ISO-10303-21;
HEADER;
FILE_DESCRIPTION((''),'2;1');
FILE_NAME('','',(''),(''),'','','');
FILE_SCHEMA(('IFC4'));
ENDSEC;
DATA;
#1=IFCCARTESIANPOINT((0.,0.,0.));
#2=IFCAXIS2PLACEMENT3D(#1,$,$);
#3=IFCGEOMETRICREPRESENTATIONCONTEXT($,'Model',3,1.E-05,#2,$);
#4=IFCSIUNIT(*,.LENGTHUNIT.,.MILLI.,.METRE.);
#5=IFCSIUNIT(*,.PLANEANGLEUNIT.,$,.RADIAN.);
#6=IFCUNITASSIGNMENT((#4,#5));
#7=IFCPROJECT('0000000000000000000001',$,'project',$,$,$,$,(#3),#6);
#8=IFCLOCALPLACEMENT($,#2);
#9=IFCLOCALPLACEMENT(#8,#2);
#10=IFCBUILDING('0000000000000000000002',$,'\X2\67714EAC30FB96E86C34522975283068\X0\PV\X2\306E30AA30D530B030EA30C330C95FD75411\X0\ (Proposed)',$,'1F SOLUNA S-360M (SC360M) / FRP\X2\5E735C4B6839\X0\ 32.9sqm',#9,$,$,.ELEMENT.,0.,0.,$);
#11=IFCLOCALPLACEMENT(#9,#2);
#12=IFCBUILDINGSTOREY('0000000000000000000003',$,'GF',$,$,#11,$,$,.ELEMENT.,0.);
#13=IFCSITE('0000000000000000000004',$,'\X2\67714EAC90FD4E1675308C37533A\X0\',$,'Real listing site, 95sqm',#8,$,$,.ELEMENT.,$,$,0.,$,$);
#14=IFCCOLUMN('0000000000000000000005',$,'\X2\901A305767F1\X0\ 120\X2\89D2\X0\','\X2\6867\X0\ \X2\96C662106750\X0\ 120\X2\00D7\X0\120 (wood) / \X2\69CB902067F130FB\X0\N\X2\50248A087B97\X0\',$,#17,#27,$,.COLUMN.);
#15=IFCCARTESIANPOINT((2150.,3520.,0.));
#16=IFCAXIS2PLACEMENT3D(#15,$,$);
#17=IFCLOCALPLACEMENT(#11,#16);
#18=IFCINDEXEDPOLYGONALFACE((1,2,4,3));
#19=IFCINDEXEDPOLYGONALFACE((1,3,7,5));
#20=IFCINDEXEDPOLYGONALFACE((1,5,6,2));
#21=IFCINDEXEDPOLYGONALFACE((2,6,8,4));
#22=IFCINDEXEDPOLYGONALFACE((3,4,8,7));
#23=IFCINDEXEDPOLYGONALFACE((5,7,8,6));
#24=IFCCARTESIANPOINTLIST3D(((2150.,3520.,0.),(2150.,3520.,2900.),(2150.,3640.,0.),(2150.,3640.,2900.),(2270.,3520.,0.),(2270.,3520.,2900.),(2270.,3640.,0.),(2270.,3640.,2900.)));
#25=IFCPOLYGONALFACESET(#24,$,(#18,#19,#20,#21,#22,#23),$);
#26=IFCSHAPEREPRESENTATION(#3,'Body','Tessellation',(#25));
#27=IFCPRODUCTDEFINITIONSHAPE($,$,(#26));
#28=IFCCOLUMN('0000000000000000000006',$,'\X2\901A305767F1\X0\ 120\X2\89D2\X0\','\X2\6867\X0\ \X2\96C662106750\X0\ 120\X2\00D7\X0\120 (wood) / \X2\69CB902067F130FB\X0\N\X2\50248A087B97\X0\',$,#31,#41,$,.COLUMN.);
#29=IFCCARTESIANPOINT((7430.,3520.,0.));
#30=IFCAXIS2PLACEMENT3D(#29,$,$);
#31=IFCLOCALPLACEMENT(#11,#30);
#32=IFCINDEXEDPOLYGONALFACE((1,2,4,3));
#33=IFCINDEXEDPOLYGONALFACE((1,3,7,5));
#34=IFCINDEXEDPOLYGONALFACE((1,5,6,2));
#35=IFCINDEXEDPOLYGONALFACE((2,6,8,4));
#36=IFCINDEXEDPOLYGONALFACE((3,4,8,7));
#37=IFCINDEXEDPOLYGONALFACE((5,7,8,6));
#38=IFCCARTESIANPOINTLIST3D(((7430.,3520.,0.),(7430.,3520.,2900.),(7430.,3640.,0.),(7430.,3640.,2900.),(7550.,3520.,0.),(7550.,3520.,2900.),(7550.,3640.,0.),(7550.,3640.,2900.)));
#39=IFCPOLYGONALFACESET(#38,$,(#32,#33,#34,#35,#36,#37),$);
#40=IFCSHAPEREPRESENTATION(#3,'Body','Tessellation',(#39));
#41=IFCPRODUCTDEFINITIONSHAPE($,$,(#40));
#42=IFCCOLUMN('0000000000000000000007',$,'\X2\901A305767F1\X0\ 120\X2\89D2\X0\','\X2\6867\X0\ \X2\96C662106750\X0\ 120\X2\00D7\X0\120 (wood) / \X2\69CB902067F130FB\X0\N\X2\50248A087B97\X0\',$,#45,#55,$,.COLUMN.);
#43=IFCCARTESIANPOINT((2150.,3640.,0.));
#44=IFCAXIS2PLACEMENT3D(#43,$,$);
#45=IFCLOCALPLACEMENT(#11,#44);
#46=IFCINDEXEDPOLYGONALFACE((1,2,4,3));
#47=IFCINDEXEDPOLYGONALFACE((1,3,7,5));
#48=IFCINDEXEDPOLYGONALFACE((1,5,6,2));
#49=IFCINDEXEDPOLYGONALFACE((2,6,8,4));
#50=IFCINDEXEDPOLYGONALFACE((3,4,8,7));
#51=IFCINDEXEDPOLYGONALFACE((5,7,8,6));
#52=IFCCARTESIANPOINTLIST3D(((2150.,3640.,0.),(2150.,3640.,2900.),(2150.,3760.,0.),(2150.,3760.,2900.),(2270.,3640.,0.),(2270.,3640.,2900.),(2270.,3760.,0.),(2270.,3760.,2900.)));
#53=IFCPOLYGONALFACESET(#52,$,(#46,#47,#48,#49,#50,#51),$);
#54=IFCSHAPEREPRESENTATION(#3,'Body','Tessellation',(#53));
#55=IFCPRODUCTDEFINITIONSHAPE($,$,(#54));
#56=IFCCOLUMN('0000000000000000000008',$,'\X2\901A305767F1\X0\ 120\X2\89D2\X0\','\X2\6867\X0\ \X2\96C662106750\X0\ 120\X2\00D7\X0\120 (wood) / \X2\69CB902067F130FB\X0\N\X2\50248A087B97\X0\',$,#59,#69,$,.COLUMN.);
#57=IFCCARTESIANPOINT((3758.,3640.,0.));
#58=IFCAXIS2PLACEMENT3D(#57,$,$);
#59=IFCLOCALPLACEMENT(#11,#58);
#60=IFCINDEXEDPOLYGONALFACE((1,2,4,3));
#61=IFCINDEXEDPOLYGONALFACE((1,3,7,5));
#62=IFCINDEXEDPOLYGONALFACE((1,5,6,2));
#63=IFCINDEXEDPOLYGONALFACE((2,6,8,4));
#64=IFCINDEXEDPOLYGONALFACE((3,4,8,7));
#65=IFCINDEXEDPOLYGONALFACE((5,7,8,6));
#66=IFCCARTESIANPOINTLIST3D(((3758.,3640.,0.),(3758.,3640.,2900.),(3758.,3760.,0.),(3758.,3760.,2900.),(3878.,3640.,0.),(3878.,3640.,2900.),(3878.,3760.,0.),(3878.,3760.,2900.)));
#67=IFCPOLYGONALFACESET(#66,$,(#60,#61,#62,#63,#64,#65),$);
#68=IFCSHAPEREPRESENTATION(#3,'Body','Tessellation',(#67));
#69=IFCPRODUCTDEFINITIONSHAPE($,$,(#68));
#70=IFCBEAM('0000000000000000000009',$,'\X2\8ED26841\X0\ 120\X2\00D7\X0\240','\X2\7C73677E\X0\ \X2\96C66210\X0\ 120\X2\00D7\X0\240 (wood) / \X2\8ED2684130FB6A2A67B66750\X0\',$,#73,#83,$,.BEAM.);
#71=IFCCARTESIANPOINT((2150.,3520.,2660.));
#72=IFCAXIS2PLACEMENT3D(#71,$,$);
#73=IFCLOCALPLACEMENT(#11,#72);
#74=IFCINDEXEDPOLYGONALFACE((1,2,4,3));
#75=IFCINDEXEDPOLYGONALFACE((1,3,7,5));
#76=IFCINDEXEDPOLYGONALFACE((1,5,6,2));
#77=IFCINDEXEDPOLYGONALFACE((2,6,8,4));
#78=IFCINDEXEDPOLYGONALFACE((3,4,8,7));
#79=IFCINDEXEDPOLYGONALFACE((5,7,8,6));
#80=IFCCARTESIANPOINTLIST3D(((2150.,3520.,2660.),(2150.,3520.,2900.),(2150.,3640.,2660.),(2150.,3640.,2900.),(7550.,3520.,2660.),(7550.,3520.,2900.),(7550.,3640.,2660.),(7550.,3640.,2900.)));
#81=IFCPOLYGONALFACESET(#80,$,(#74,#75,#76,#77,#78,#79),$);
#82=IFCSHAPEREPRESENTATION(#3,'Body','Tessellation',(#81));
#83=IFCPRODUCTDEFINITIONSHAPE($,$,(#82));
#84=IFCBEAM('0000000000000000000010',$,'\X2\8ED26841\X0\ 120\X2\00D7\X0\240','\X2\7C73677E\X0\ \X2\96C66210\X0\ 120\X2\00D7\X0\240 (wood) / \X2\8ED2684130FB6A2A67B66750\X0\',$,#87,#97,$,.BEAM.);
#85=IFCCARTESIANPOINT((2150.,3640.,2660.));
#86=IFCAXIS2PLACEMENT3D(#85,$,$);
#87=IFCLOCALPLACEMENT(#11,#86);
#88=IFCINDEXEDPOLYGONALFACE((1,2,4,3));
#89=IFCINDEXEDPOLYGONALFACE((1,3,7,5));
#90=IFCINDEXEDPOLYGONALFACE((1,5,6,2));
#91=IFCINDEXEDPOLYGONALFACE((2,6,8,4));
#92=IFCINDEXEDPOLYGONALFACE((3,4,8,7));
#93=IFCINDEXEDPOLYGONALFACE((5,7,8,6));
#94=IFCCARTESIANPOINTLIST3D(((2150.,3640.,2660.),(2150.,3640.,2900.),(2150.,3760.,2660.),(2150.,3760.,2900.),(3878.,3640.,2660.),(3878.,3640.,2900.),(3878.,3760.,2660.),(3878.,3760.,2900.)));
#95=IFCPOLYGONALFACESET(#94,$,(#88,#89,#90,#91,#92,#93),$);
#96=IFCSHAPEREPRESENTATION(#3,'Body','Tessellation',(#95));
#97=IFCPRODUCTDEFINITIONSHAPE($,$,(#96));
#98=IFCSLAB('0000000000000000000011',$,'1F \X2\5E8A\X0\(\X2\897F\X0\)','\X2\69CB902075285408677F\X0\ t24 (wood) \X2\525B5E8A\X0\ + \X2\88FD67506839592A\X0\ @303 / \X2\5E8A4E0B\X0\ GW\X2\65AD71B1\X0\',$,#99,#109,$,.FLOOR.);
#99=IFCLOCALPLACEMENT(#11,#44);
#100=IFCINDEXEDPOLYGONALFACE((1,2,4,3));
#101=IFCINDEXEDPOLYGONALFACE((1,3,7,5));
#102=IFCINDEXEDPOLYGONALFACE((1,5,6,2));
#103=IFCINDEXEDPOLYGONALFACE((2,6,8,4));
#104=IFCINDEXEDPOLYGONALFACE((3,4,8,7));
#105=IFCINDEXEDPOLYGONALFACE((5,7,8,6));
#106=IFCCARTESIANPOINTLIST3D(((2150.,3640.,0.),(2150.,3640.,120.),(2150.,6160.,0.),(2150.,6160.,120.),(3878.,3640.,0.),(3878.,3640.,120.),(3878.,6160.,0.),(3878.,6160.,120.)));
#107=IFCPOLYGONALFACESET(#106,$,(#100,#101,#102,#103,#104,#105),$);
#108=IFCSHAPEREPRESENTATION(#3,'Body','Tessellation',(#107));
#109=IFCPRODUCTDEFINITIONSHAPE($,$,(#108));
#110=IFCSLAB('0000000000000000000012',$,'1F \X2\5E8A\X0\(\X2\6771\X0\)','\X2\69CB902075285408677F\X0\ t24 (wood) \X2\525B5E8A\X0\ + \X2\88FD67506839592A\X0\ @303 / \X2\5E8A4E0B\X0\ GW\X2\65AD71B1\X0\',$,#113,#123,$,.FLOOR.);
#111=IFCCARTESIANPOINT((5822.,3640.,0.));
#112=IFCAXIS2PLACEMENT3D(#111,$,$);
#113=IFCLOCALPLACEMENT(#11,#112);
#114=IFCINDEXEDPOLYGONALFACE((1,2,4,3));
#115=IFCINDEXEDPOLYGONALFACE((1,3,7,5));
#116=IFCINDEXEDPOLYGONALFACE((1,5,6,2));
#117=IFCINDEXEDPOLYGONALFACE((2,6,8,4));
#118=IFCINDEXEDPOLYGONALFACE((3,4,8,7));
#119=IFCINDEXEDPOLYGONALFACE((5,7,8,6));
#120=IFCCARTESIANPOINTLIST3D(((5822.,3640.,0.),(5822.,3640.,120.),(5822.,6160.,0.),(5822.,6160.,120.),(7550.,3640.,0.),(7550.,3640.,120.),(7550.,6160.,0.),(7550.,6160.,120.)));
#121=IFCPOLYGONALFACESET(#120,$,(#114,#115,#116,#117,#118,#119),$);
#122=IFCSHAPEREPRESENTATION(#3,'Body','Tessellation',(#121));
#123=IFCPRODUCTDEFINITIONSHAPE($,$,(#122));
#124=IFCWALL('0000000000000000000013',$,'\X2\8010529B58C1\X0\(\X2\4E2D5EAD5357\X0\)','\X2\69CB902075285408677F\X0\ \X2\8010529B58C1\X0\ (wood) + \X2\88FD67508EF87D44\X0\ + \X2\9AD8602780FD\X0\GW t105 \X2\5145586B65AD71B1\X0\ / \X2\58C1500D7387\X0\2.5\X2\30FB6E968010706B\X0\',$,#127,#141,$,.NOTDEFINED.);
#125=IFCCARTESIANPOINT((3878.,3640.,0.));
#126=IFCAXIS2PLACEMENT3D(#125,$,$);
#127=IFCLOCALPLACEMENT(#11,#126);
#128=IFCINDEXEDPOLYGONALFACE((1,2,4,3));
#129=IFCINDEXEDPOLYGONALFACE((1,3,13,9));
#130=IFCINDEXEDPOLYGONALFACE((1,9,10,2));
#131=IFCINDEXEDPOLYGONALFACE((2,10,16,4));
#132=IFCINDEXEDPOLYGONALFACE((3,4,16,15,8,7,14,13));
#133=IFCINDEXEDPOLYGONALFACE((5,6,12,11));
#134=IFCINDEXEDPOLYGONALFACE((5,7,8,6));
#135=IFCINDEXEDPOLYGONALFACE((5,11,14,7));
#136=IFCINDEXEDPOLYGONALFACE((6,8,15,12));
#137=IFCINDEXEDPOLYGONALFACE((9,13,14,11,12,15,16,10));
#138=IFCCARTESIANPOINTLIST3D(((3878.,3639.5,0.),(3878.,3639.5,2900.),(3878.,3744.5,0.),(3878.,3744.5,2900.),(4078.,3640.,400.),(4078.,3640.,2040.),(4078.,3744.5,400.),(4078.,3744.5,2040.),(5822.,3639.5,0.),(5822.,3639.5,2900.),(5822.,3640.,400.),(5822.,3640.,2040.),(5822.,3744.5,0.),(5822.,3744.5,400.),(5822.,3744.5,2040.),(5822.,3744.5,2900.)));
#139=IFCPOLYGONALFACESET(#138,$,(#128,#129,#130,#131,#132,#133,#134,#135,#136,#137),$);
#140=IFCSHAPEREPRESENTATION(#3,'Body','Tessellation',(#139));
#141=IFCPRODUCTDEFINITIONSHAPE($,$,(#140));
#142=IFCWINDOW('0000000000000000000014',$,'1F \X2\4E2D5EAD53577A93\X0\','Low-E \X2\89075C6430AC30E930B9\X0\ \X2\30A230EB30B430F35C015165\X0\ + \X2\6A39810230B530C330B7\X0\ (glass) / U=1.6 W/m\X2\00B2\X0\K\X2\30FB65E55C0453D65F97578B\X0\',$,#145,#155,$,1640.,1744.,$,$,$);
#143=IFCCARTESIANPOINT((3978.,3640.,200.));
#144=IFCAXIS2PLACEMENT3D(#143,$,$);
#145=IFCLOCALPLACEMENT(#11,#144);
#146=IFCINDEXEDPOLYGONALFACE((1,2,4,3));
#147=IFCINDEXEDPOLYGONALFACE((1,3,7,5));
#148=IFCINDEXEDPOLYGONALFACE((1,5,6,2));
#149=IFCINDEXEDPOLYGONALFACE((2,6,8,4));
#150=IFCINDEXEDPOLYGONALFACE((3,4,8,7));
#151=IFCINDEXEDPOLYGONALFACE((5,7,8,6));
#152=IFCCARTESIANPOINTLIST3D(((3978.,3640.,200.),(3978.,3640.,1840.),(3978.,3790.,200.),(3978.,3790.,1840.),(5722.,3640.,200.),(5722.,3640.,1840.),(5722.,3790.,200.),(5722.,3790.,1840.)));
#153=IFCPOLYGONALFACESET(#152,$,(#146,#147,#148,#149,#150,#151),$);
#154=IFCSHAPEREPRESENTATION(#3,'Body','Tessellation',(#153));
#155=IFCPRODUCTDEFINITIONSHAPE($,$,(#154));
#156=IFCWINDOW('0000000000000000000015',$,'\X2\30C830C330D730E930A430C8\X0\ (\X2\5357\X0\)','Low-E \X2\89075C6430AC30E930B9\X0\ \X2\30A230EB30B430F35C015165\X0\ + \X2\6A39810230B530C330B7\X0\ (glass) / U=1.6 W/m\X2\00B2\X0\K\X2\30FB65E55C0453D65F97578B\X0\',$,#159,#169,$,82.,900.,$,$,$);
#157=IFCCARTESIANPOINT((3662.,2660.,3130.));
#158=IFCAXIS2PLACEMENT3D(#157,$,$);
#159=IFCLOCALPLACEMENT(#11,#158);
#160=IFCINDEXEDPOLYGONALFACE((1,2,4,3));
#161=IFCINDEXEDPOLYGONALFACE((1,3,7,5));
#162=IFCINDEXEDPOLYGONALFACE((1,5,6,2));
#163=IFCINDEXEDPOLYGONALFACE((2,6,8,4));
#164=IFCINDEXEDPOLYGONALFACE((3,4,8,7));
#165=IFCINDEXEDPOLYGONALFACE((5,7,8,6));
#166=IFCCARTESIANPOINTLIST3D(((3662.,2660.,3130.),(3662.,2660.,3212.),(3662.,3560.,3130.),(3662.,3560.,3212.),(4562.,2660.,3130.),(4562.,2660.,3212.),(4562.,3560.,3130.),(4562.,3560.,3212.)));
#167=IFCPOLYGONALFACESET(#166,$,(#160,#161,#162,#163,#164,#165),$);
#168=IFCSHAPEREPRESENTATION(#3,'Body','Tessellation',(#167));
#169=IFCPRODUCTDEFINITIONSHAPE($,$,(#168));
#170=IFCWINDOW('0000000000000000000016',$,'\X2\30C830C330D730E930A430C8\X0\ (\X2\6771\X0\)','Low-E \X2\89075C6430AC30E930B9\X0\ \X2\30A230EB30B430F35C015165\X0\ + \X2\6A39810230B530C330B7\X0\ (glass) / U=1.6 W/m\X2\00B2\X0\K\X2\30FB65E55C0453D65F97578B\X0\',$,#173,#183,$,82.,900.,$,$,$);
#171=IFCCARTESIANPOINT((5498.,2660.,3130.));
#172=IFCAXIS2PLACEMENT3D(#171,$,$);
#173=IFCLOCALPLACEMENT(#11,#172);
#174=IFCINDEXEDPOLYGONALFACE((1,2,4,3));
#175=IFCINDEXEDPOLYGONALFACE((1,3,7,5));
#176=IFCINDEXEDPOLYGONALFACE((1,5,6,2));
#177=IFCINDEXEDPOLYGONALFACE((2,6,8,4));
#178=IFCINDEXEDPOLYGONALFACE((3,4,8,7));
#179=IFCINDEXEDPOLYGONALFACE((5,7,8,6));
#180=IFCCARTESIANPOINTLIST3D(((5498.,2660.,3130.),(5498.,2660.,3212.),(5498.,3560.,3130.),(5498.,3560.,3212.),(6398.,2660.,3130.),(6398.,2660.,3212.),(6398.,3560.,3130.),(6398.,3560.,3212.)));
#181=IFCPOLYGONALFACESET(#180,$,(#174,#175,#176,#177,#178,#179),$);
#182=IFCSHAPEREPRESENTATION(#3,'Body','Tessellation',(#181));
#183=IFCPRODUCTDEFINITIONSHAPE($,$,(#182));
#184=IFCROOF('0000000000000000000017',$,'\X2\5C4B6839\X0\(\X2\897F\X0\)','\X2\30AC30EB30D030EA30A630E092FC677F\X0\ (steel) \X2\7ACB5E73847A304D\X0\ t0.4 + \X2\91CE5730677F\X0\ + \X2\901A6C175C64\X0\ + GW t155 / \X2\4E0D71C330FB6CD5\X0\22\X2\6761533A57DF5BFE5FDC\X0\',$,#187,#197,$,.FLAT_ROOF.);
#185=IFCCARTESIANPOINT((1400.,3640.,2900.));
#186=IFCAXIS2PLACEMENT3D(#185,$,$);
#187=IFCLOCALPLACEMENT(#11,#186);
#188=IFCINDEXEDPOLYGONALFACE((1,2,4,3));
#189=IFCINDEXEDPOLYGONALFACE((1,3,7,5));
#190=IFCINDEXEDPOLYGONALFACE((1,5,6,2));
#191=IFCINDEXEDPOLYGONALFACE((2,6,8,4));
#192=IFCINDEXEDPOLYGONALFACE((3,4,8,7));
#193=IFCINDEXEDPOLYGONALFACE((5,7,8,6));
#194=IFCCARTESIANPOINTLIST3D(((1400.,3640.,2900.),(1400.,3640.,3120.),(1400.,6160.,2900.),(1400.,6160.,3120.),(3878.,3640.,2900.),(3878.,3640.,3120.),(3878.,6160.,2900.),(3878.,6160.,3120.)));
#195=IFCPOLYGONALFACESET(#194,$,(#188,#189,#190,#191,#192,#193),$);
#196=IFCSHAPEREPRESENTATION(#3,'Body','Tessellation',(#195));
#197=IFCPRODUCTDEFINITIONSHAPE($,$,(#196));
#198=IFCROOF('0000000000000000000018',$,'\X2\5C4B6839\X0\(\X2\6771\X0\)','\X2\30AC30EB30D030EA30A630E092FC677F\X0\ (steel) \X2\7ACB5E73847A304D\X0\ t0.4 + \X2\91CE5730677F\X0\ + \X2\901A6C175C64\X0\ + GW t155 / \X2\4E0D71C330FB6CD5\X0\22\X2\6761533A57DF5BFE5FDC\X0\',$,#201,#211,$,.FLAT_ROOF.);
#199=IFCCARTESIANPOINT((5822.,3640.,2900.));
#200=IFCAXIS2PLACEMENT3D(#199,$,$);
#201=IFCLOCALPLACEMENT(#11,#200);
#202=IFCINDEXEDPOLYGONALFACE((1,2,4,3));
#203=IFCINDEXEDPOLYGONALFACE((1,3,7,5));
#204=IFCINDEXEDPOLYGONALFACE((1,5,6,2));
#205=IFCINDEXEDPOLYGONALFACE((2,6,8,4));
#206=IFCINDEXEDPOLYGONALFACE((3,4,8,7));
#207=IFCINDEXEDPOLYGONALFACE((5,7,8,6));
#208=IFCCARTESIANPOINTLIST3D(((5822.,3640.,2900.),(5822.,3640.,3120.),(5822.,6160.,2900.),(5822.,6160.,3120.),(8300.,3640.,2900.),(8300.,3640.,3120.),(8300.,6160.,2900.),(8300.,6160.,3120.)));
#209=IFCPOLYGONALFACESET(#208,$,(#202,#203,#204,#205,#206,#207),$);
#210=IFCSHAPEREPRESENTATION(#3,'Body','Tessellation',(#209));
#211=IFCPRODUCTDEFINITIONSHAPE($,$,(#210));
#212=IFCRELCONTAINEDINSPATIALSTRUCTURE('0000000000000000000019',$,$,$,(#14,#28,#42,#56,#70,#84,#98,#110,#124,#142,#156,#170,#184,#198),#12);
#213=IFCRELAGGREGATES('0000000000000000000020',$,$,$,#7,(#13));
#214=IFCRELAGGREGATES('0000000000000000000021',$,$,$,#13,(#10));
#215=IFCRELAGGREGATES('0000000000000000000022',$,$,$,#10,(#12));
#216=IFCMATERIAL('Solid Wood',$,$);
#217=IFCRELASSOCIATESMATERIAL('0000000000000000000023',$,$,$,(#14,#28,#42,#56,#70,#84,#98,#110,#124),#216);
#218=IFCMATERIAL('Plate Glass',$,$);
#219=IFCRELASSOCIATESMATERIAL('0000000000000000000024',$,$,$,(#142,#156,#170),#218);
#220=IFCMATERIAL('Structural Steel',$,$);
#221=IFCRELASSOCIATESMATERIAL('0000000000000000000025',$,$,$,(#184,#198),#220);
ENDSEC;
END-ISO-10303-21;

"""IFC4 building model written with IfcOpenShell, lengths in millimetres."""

from ifc_helpers import new_model, si_unit, frame, frame_2d, origin, place, context, project, spatial, rectangle, extrude, material, element, fill, save


model = new_model("IFC4")

# Units and contexts
model_context = context("Model", 3, precision=1e-05, world=origin())
ifc_project = project(units=[si_unit("LENGTHUNIT", "METRE", prefix="MILLI"), si_unit("PLANEANGLEUNIT", "RADIAN")], contexts=[model_context])

# Site, building, storey
site_placement = place(None, origin())
site = spatial("IfcSite", under=ifc_project, at=site_placement, Name="東京都世田谷区", ObjectType="Real listing site, 95sqm", CompositionType="ELEMENT", RefElevation=0.0)
building_placement = place(site_placement, origin())
building = spatial("IfcBuilding", under=site, at=building_placement, Name="東京・雨水利用とPVのオフグリッド志向 (Proposed)", ObjectType="1F SOLUNA S-360M (SC360M) / FRP平屋根 32.9sqm", CompositionType="ELEMENT", ElevationOfRefHeight=0.0, ElevationOfTerrain=0.0)
storey_placement = place(building_placement, origin())
storey = spatial("IfcBuildingStorey", under=building, at=storey_placement, Name="GF", CompositionType="ELEMENT", Elevation=0.0)

# Columns
ifc_material_1 = material(Name="Solid Wood")
column_1_placement = place(storey_placement, frame((2150.0, 3520.0, 0.0)))
element("IfcColumn", 1, at=column_1_placement, inside=storey, material=ifc_material_1, Name="通し柱 120角", Description="桧 集成材 120×120 (wood) / 構造柱・N値計算", PredefinedType="COLUMN", context=model_context, shape_type="SweptSolid", body=[
    extrude(rectangle(XDim=120.0, YDim=120.0, at=frame_2d((60.0, 60.0))), frame((2150.0, 3520.0, 0.0)), (0.0, 0.0, 1.0), 2900.0),
])
column_2_placement = place(storey_placement, frame((7430.0, 3520.0, 0.0)))
element("IfcColumn", 2, at=column_2_placement, inside=storey, material=ifc_material_1, Name="通し柱 120角", Description="桧 集成材 120×120 (wood) / 構造柱・N値計算", PredefinedType="COLUMN", context=model_context, shape_type="SweptSolid", body=[
    extrude(rectangle(XDim=120.0, YDim=120.0, at=frame_2d((60.0, 60.0))), frame((7430.0, 3520.0, 0.0)), (0.0, 0.0, 1.0), 2900.0),
])
column_3_placement = place(storey_placement, frame((2150.0, 3640.0, 0.0)))
element("IfcColumn", 3, at=column_3_placement, inside=storey, material=ifc_material_1, Name="通し柱 120角", Description="桧 集成材 120×120 (wood) / 構造柱・N値計算", PredefinedType="COLUMN", context=model_context, shape_type="SweptSolid", body=[
    extrude(rectangle(XDim=120.0, YDim=120.0, at=frame_2d((60.0, 60.0))), frame((2150.0, 3640.0, 0.0)), (0.0, 0.0, 1.0), 2900.0),
])
column_4_placement = place(storey_placement, frame((3758.0, 3640.0, 0.0)))
element("IfcColumn", 4, at=column_4_placement, inside=storey, material=ifc_material_1, Name="通し柱 120角", Description="桧 集成材 120×120 (wood) / 構造柱・N値計算", PredefinedType="COLUMN", context=model_context, shape_type="SweptSolid", body=[
    extrude(rectangle(XDim=120.0, YDim=120.0, at=frame_2d((60.0, 60.0))), frame((3758.0, 3640.0, 0.0)), (0.0, 0.0, 1.0), 2900.0),
])

# Beams
beam_1_placement = place(storey_placement, frame((2150.0, 3520.0, 2660.0)))
element("IfcBeam", 5, at=beam_1_placement, inside=storey, material=ifc_material_1, Name="軒桁 120×240", Description="米松 集成 120×240 (wood) / 軒桁・横架材", PredefinedType="BEAM", context=model_context, shape_type="SweptSolid", body=[
    extrude(rectangle(XDim=5400.0, YDim=120.0, at=frame_2d((2700.0, 60.0))), frame((2150.0, 3520.0, 2660.0)), (0.0, 0.0, 1.0), 240.0),
])
beam_2_placement = place(storey_placement, frame((2150.0, 3640.0, 2660.0)))
element("IfcBeam", 6, at=beam_2_placement, inside=storey, material=ifc_material_1, Name="軒桁 120×240", Description="米松 集成 120×240 (wood) / 軒桁・横架材", PredefinedType="BEAM", context=model_context, shape_type="SweptSolid", body=[
    extrude(rectangle(XDim=1728.0, YDim=120.0, at=frame_2d((864.0, 60.0))), frame((2150.0, 3640.0, 2660.0)), (0.0, 0.0, 1.0), 240.0),
])

# Slabs
slab_1_placement = place(storey_placement, frame((2150.0, 3640.0, 0.0)))
element("IfcSlab", 7, at=slab_1_placement, inside=storey, material=ifc_material_1, Name="1F 床(西)", Description="構造用合板 t24 (wood) 剛床 + 製材根太 @303 / 床下 GW断熱", PredefinedType="FLOOR", context=model_context, shape_type="SweptSolid", body=[
    extrude(rectangle(XDim=1728.0, YDim=2520.0, at=frame_2d((864.0, 1260.0))), frame((2150.0, 3640.0, 0.0)), (0.0, 0.0, 1.0), 120.0),
])
slab_2_placement = place(storey_placement, frame((5822.0, 3640.0, 0.0)))
element("IfcSlab", 8, at=slab_2_placement, inside=storey, material=ifc_material_1, Name="1F 床(東)", Description="構造用合板 t24 (wood) 剛床 + 製材根太 @303 / 床下 GW断熱", PredefinedType="FLOOR", context=model_context, shape_type="SweptSolid", body=[
    extrude(rectangle(XDim=1728.0, YDim=2520.0, at=frame_2d((864.0, 1260.0))), frame((5822.0, 3640.0, 0.0)), (0.0, 0.0, 1.0), 120.0),
])

# Wall, opening, window
wall_1_placement = place(storey_placement, frame((3878.0, 3640.0, 0.0)))
wall_1 = element("IfcWall", 9, at=wall_1_placement, inside=storey, material=ifc_material_1, Name="耐力壁(中庭南)", Description="構造用合板 耐力壁 (wood) + 製材軸組 + 高性能GW t105 充填断熱 / 壁倍率2.5・準耐火", PredefinedType="NOTDEFINED", context=model_context, shape_type="SweptSolid", body=[
    extrude(rectangle(XDim=1944.0, YDim=105.0, at=frame_2d((972.0, 52.0))), frame((3878.0, 3640.0, 0.0)), (0.0, 0.0, 1.0), 2900.0),
])
opening_placement = place(storey_placement, frame((3978.0, 3640.0, 200.0)))
opening = element("IfcOpeningElement", 10, at=opening_placement, cuts=wall_1, PredefinedType="NOTDEFINED", context=model_context, shape_type="SweptSolid", body=[
    extrude(rectangle(XDim=1744.0, YDim=150.0, at=frame_2d((872.0, 75.0))), frame((3978.0, 3640.0, 200.0)), (0.0, 0.0, 1.0), 1640.0),
])
ifc_material_2 = material(Name="Plate Glass")
window_1_placement = place(storey_placement, frame((3978.0, 3640.0, 200.0)))
window_1 = element("IfcWindow", 11, at=window_1_placement, inside=storey, material=ifc_material_2, Name="1F 中庭南窓", Description="Low-E 複層ガラス アルゴン封入 + 樹脂サッシ (glass) / U=1.6 W/m²K・日射取得型", OverallHeight=1640.0, OverallWidth=1744.0, context=model_context, shape_type="SweptSolid", body=[
    extrude(rectangle(XDim=1744.0, YDim=150.0, at=frame_2d((872.0, 75.0))), frame((3978.0, 3640.0, 200.0)), (0.0, 0.0, 1.0), 1640.0),
])
fill(opening, window_1)

# Windows
window_2_placement = place(storey_placement, frame((3662.0, 2660.0, 3130.0)))
element("IfcWindow", 12, at=window_2_placement, inside=storey, material=ifc_material_2, Name="トップライト (南)", Description="Low-E 複層ガラス アルゴン封入 + 樹脂サッシ (glass) / U=1.6 W/m²K・日射取得型", OverallHeight=82.0, OverallWidth=900.0, context=model_context, shape_type="SweptSolid", body=[
    extrude(rectangle(XDim=900.0, YDim=900.0, at=frame_2d((450.0, 450.0))), frame((3662.0, 2660.0, 3130.0)), (0.0, 0.0, 1.0), 82.0),
])
window_3_placement = place(storey_placement, frame((5498.0, 2660.0, 3130.0)))
element("IfcWindow", 13, at=window_3_placement, inside=storey, material=ifc_material_2, Name="トップライト (東)", Description="Low-E 複層ガラス アルゴン封入 + 樹脂サッシ (glass) / U=1.6 W/m²K・日射取得型", OverallHeight=82.0, OverallWidth=900.0, context=model_context, shape_type="SweptSolid", body=[
    extrude(rectangle(XDim=900.0, YDim=900.0, at=frame_2d((450.0, 450.0))), frame((5498.0, 2660.0, 3130.0)), (0.0, 0.0, 1.0), 82.0),
])

# Roofs
ifc_material_3 = material(Name="Structural Steel")
roof_1_placement = place(storey_placement, frame((1400.0, 3640.0, 2900.0)))
element("IfcRoof", 14, at=roof_1_placement, inside=storey, material=ifc_material_3, Name="屋根(西)", Description="ガルバリウム鋼板 (steel) 立平葺き t0.4 + 野地板 + 通気層 + GW t155 / 不燃・法22条区域対応", PredefinedType="FLAT_ROOF", context=model_context, shape_type="SweptSolid", body=[
    extrude(rectangle(XDim=2478.0, YDim=2520.0, at=frame_2d((1239.0, 1260.0))), frame((1400.0, 3640.0, 2900.0)), (0.0, 0.0, 1.0), 220.0),
])
roof_2_placement = place(storey_placement, frame((5822.0, 3640.0, 2900.0)))
element("IfcRoof", 15, at=roof_2_placement, inside=storey, material=ifc_material_3, Name="屋根(東)", Description="ガルバリウム鋼板 (steel) 立平葺き t0.4 + 野地板 + 通気層 + GW t155 / 不燃・法22条区域対応", PredefinedType="FLAT_ROOF", context=model_context, shape_type="SweptSolid", body=[
    extrude(rectangle(XDim=2478.0, YDim=2520.0, at=frame_2d((1239.0, 1260.0))), frame((5822.0, 3640.0, 2900.0)), (0.0, 0.0, 1.0), 220.0),
])

save(model, "model.ifc")
